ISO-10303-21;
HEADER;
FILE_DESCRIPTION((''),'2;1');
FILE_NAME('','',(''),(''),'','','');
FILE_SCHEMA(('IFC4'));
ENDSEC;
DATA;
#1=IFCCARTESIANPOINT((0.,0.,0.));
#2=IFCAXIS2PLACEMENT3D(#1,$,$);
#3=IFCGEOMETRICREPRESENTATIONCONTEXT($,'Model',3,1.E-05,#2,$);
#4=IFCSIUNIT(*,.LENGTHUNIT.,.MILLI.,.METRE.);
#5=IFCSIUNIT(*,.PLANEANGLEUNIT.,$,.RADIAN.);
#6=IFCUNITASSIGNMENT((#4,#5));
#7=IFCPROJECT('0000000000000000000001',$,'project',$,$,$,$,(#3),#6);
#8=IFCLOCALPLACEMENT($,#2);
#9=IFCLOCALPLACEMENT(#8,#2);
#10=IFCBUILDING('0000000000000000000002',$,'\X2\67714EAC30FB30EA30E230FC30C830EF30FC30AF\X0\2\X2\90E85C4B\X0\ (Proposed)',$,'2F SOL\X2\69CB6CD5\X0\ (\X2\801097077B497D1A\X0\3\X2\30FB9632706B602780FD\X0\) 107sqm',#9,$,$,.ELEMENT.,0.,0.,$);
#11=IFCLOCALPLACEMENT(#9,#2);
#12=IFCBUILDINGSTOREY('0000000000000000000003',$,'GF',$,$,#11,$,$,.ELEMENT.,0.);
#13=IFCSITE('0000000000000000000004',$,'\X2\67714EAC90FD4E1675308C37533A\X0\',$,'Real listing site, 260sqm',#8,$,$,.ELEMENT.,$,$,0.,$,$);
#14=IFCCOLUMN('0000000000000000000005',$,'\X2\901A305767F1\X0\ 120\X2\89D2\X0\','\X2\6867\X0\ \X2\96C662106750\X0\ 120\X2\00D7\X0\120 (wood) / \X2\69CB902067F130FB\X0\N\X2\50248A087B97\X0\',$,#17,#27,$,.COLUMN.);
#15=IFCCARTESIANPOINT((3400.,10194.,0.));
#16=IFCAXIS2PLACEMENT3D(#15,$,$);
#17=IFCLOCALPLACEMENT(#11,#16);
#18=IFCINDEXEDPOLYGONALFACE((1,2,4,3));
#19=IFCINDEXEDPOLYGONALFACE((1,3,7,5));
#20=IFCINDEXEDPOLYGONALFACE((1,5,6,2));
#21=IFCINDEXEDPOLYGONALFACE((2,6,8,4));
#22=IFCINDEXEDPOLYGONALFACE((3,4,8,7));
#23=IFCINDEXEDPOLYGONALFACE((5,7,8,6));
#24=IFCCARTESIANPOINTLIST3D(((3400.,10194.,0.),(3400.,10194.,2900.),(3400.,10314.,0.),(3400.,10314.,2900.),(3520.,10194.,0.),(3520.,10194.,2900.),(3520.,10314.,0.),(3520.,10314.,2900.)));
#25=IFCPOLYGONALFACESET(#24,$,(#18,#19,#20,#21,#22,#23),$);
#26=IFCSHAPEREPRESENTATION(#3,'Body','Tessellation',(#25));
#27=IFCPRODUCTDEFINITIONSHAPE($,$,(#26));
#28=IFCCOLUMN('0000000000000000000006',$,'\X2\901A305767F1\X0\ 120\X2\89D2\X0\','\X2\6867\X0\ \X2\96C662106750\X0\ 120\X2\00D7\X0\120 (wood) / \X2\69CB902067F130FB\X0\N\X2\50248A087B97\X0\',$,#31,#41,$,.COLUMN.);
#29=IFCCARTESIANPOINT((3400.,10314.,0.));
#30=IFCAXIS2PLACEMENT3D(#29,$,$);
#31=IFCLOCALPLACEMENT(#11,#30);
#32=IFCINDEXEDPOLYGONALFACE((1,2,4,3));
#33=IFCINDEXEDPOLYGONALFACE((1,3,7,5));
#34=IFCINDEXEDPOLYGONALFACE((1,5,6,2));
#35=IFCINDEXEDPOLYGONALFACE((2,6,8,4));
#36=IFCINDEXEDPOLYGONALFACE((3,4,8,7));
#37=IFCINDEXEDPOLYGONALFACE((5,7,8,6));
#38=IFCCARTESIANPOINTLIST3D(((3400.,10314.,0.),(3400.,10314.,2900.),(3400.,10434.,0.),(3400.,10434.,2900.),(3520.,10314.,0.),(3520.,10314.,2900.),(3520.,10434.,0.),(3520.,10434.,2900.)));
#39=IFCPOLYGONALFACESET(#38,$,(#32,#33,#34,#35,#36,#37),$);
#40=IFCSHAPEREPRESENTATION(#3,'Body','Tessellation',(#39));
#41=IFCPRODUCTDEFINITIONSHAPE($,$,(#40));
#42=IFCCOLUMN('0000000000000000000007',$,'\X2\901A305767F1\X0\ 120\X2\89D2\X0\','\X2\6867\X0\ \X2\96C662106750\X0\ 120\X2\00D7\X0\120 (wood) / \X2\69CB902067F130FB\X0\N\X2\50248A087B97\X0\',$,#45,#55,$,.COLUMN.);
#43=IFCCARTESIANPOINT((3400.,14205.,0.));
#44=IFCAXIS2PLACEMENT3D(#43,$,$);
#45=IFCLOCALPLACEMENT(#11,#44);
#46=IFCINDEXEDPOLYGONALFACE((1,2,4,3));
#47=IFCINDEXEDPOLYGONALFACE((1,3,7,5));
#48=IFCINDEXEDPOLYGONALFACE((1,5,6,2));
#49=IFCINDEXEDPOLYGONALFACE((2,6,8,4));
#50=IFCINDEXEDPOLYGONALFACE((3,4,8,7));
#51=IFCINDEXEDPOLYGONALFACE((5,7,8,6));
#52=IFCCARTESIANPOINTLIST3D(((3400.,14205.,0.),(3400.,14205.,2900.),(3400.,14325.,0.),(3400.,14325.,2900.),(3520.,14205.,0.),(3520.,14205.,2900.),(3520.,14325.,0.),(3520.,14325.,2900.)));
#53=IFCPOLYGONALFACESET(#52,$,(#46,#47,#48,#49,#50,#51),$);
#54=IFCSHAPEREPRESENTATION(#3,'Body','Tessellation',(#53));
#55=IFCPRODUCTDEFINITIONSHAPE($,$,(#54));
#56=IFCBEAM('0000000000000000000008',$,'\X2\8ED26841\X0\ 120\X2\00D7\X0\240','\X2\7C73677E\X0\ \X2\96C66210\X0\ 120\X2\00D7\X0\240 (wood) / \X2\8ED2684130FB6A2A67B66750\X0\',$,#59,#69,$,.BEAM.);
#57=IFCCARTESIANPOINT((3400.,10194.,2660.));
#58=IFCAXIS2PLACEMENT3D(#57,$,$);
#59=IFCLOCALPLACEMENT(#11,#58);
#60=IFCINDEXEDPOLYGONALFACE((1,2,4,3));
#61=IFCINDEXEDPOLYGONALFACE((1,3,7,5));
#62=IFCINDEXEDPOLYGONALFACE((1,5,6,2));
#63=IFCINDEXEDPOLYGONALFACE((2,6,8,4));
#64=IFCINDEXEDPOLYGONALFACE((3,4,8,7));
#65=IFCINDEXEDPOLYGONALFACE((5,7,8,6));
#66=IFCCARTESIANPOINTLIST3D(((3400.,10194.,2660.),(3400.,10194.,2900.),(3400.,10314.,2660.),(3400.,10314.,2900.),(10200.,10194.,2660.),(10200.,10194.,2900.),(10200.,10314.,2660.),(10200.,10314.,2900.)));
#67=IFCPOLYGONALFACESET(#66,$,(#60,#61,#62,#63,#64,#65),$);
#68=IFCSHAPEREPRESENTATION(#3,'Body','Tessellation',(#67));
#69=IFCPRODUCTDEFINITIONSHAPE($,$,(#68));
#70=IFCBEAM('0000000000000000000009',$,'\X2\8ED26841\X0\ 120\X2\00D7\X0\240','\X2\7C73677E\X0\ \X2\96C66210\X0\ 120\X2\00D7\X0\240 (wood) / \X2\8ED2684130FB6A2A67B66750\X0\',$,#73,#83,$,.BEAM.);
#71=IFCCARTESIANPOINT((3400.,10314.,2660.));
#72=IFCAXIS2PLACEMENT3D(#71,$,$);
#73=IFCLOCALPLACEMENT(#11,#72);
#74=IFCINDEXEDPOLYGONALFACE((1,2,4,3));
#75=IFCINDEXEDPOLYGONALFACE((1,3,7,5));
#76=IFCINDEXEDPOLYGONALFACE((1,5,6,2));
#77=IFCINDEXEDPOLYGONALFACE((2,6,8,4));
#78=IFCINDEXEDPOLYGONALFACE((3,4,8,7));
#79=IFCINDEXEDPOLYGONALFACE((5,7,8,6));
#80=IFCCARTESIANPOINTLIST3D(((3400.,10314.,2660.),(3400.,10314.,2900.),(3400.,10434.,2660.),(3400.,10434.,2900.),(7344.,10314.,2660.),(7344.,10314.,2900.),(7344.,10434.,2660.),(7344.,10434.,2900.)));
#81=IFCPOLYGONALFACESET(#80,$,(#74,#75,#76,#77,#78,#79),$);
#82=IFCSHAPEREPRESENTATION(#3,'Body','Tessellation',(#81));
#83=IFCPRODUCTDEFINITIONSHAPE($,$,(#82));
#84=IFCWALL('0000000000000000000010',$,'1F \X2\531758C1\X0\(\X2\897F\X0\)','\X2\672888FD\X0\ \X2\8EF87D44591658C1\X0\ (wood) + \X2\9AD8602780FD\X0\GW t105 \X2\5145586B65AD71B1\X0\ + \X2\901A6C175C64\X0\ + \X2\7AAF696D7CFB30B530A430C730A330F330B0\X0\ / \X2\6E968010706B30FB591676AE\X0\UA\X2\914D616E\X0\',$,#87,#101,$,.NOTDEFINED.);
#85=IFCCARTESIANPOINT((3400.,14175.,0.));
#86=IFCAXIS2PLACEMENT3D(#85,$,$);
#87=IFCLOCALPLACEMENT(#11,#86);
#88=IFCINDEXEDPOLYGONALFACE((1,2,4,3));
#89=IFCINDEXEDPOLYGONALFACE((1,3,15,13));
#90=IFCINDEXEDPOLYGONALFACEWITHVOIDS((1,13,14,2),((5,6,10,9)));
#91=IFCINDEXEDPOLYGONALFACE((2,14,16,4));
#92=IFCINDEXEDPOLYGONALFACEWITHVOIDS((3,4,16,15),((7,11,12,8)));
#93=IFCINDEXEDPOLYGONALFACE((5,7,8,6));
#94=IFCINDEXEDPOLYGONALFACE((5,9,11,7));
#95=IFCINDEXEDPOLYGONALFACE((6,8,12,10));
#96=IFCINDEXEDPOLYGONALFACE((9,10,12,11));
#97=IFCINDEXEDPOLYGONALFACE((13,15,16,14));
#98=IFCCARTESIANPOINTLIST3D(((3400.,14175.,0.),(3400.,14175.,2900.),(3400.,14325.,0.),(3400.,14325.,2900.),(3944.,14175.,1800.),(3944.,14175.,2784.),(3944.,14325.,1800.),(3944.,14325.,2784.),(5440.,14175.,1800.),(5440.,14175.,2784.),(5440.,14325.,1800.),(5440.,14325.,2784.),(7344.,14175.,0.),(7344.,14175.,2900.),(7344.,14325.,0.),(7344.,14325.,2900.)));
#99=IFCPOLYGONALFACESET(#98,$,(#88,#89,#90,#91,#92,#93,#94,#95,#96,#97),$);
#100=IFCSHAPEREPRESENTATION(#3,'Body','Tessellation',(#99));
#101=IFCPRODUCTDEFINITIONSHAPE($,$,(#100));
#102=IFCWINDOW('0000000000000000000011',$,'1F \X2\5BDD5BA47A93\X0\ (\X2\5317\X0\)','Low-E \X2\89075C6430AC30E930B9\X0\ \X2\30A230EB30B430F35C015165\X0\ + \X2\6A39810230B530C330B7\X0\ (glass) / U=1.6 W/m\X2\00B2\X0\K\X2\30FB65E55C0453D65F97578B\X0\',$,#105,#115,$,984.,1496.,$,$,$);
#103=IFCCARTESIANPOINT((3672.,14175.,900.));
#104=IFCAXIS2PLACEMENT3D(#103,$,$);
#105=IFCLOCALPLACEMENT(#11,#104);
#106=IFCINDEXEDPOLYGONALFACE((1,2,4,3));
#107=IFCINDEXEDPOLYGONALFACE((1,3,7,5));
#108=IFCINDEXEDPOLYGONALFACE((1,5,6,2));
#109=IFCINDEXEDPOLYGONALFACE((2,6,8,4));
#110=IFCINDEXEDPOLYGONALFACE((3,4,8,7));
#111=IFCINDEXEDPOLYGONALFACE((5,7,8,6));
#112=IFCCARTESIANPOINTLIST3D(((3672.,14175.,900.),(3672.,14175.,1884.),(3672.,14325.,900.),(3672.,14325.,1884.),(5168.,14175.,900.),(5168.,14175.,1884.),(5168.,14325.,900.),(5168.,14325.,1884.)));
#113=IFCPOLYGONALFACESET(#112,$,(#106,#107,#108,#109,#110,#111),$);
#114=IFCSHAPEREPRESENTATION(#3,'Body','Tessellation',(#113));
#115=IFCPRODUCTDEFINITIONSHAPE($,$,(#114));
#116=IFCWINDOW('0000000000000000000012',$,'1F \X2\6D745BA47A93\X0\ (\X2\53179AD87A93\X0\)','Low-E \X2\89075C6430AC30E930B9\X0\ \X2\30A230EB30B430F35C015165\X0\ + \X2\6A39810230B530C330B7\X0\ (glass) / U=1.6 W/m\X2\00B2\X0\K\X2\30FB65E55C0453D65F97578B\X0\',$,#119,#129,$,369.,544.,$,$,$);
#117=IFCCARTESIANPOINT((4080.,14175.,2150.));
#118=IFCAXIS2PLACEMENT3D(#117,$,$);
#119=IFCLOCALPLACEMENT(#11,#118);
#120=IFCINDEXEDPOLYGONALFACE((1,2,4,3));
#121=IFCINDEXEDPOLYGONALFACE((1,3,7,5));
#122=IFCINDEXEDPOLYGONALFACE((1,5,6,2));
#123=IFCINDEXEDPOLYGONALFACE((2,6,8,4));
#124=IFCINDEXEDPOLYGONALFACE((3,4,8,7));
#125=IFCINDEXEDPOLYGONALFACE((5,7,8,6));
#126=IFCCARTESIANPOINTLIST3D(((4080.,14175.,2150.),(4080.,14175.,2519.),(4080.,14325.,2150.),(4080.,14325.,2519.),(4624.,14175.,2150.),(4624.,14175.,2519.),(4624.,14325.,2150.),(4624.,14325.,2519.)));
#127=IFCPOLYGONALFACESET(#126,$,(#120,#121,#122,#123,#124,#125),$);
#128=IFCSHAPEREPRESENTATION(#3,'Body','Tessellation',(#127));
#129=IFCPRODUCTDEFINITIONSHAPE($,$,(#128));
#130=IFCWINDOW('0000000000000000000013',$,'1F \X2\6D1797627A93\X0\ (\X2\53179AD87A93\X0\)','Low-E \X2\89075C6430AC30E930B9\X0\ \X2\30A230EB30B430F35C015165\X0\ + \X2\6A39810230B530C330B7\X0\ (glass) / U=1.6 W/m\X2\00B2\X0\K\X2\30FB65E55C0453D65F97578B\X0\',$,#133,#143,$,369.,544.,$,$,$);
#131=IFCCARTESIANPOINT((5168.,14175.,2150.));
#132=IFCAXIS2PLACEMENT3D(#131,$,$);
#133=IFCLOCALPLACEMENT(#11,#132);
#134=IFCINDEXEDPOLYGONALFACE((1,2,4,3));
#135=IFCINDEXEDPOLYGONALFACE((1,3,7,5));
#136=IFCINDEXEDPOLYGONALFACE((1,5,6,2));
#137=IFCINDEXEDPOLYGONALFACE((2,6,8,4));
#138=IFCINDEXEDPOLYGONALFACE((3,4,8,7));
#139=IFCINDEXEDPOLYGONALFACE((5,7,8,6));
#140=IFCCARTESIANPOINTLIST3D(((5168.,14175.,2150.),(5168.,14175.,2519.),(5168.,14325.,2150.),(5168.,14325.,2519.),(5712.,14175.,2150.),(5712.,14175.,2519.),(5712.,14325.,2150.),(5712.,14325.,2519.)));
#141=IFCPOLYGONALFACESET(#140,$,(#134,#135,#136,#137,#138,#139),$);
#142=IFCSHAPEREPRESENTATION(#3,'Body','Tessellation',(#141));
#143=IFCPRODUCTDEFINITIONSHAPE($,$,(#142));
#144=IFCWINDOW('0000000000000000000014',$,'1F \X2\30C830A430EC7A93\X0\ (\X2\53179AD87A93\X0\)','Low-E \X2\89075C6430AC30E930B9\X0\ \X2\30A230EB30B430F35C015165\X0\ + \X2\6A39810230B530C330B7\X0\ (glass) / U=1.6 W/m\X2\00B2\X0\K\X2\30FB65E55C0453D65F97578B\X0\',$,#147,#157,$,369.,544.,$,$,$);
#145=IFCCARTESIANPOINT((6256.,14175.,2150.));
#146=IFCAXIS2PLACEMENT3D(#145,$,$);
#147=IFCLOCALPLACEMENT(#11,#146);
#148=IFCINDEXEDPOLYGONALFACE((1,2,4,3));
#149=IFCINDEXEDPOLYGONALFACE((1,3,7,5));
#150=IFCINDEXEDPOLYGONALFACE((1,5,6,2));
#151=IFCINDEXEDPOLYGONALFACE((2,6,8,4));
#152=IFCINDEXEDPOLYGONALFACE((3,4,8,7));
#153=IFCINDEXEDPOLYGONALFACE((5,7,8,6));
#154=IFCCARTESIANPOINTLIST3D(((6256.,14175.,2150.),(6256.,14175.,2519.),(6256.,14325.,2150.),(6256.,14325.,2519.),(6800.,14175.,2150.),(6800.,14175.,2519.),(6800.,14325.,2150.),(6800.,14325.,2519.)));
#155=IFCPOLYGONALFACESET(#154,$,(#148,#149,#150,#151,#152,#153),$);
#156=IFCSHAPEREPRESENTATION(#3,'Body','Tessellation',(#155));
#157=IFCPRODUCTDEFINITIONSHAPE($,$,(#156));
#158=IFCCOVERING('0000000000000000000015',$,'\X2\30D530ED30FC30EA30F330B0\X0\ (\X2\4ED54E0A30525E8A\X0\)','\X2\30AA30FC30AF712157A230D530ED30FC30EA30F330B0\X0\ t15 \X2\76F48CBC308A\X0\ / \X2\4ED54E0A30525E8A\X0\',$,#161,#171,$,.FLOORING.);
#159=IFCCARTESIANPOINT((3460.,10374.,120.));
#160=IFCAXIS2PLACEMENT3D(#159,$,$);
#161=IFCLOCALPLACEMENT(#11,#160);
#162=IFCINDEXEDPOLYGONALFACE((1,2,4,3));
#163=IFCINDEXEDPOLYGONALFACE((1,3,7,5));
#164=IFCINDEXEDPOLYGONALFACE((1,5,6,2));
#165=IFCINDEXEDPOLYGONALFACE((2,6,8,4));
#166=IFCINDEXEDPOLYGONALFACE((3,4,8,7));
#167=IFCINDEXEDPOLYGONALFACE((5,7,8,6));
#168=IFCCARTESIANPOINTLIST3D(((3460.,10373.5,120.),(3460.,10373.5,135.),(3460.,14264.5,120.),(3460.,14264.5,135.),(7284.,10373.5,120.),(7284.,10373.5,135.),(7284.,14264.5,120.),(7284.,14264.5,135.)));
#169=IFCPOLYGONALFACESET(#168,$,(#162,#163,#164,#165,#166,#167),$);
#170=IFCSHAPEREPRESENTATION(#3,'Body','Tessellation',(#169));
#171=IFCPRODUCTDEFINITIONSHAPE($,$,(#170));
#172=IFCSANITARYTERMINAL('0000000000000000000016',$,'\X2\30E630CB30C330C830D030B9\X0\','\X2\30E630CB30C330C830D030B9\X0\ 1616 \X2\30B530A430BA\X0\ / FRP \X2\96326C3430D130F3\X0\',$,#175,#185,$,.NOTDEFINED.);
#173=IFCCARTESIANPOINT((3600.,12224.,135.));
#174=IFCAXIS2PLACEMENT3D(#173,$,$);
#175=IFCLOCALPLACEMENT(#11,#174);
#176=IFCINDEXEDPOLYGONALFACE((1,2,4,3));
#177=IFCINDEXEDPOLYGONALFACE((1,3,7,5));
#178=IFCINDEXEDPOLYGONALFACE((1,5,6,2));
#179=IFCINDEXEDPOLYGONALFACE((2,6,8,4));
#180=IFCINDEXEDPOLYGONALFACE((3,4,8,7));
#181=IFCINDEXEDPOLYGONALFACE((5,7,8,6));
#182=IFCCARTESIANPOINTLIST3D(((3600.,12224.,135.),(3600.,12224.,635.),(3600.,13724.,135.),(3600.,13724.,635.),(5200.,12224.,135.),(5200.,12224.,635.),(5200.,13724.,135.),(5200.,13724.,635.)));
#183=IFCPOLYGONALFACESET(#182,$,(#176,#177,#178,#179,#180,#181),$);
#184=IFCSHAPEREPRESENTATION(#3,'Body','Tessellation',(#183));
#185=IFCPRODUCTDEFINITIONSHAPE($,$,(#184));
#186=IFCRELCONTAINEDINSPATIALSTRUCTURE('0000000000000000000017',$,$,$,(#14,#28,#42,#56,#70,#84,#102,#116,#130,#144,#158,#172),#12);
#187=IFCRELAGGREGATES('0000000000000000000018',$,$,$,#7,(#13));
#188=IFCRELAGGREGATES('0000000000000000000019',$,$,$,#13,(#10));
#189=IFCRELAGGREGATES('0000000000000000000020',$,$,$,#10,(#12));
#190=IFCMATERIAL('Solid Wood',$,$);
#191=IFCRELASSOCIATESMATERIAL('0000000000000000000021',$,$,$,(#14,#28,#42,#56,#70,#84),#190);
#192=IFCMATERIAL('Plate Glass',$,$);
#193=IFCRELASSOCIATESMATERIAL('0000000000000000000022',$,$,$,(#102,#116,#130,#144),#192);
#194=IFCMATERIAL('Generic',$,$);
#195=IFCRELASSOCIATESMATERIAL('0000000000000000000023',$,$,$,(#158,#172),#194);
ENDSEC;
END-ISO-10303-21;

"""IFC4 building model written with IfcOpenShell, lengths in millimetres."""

from ifc_helpers import new_model, si_unit, frame, frame_2d, origin, place, context, project, spatial, rectangle, extrude, material, element, fill, save


model = new_model("IFC4")

# Units and contexts
model_context = context("Model", 3, precision=1e-05, world=origin())
ifc_project = project(units=[si_unit("LENGTHUNIT", "METRE", prefix="MILLI"), si_unit("PLANEANGLEUNIT", "RADIAN")], contexts=[model_context])

# Site, building, storey
site_placement = place(None, origin())
site = spatial("IfcSite", under=ifc_project, at=site_placement, Name="東京都世田谷区", ObjectType="Real listing site, 260sqm", CompositionType="ELEMENT", RefElevation=0.0)
building_placement = place(site_placement, origin())
building = spatial("IfcBuilding", under=site, at=building_placement, Name="東京・リモートワーク2部屋 (Proposed)", ObjectType="2F SOL構法 (耐震等級3・防火性能) 107sqm", CompositionType="ELEMENT", ElevationOfRefHeight=0.0, ElevationOfTerrain=0.0)
storey_placement = place(building_placement, origin())
storey = spatial("IfcBuildingStorey", under=building, at=storey_placement, Name="GF", CompositionType="ELEMENT", Elevation=0.0)

# Columns
ifc_material_1 = material(Name="Solid Wood")
column_1_placement = place(storey_placement, frame((3400.0, 10194.0, 0.0)))
element("IfcColumn", 1, at=column_1_placement, inside=storey, material=ifc_material_1, Name="通し柱 120角", Description="桧 集成材 120×120 (wood) / 構造柱・N値計算", PredefinedType="COLUMN", context=model_context, shape_type="SweptSolid", body=[
    extrude(rectangle(XDim=120.0, YDim=120.0, at=frame_2d((60.0, 60.0))), frame((3400.0, 10194.0, 0.0)), (0.0, 0.0, 1.0), 2900.0),
])
column_2_placement = place(storey_placement, frame((3400.0, 10314.0, 0.0)))
element("IfcColumn", 2, at=column_2_placement, inside=storey, material=ifc_material_1, Name="通し柱 120角", Description="桧 集成材 120×120 (wood) / 構造柱・N値計算", PredefinedType="COLUMN", context=model_context, shape_type="SweptSolid", body=[
    extrude(rectangle(XDim=120.0, YDim=120.0, at=frame_2d((60.0, 60.0))), frame((3400.0, 10314.0, 0.0)), (0.0, 0.0, 1.0), 2900.0),
])
column_3_placement = place(storey_placement, frame((3400.0, 14205.0, 0.0)))
element("IfcColumn", 3, at=column_3_placement, inside=storey, material=ifc_material_1, Name="通し柱 120角", Description="桧 集成材 120×120 (wood) / 構造柱・N値計算", PredefinedType="COLUMN", context=model_context, shape_type="SweptSolid", body=[
    extrude(rectangle(XDim=120.0, YDim=120.0, at=frame_2d((60.0, 60.0))), frame((3400.0, 14205.0, 0.0)), (0.0, 0.0, 1.0), 2900.0),
])

# Beams
beam_1_placement = place(storey_placement, frame((3400.0, 10194.0, 2660.0)))
element("IfcBeam", 4, at=beam_1_placement, inside=storey, material=ifc_material_1, Name="軒桁 120×240", Description="米松 集成 120×240 (wood) / 軒桁・横架材", PredefinedType="BEAM", context=model_context, shape_type="SweptSolid", body=[
    extrude(rectangle(XDim=6800.0, YDim=120.0, at=frame_2d((3400.0, 60.0))), frame((3400.0, 10194.0, 2660.0)), (0.0, 0.0, 1.0), 240.0),
])
beam_2_placement = place(storey_placement, frame((3400.0, 10314.0, 2660.0)))
element("IfcBeam", 5, at=beam_2_placement, inside=storey, material=ifc_material_1, Name="軒桁 120×240", Description="米松 集成 120×240 (wood) / 軒桁・横架材", PredefinedType="BEAM", context=model_context, shape_type="SweptSolid", body=[
    extrude(rectangle(XDim=3944.0, YDim=120.0, at=frame_2d((1972.0, 60.0))), frame((3400.0, 10314.0, 2660.0)), (0.0, 0.0, 1.0), 240.0),
])

# Wall, openings, windows
wall_1_placement = place(storey_placement, frame((3400.0, 14175.0, 0.0)))
wall_1 = element("IfcWall", 6, at=wall_1_placement, inside=storey, material=ifc_material_1, Name="1F 北壁(西)", Description="木製 軸組外壁 (wood) + 高性能GW t105 充填断熱 + 通気層 + 窯業系サイディング / 準耐火・外皮UA配慮", PredefinedType="NOTDEFINED", context=model_context, shape_type="SweptSolid", body=[
    extrude(rectangle(XDim=3944.0, YDim=150.0, at=frame_2d((1972.0, 75.0))), frame((3400.0, 14175.0, 0.0)), (0.0, 0.0, 1.0), 2900.0),
])
opening_1_placement = place(storey_placement, frame((3672.0, 14175.0, 900.0)))
opening_1 = element("IfcOpeningElement", 7, at=opening_1_placement, cuts=wall_1, PredefinedType="NOTDEFINED", context=model_context, shape_type="SweptSolid", body=[
    extrude(rectangle(XDim=1496.0, YDim=150.0, at=frame_2d((748.0, 75.0))), frame((3672.0, 14175.0, 900.0)), (0.0, 0.0, 1.0), 984.0),
])
opening_2_placement = place(storey_placement, frame((4080.0, 14175.0, 2150.0)))
opening_2 = element("IfcOpeningElement", 8, at=opening_2_placement, cuts=wall_1, PredefinedType="NOTDEFINED", context=model_context, shape_type="SweptSolid", body=[
    extrude(rectangle(XDim=544.0, YDim=150.0, at=frame_2d((272.0, 75.0))), frame((4080.0, 14175.0, 2150.0)), (0.0, 0.0, 1.0), 369.0),
])
opening_3_placement = place(storey_placement, frame((5168.0, 14175.0, 2150.0)))
opening_3 = element("IfcOpeningElement", 9, at=opening_3_placement, cuts=wall_1, PredefinedType="NOTDEFINED", context=model_context, shape_type="SweptSolid", body=[
    extrude(rectangle(XDim=544.0, YDim=150.0, at=frame_2d((272.0, 75.0))), frame((5168.0, 14175.0, 2150.0)), (0.0, 0.0, 1.0), 369.0),
])
opening_4_placement = place(storey_placement, frame((6256.0, 14175.0, 2150.0)))
opening_4 = element("IfcOpeningElement", 10, at=opening_4_placement, cuts=wall_1, PredefinedType="NOTDEFINED", context=model_context, shape_type="SweptSolid", body=[
    extrude(rectangle(XDim=544.0, YDim=150.0, at=frame_2d((272.0, 75.0))), frame((6256.0, 14175.0, 2150.0)), (0.0, 0.0, 1.0), 369.0),
])
ifc_material_2 = material(Name="Plate Glass")
window_1_placement = place(storey_placement, frame((3672.0, 14175.0, 900.0)))
window_1 = element("IfcWindow", 11, at=window_1_placement, inside=storey, material=ifc_material_2, Name="1F 寝室窓 (北)", Description="Low-E 複層ガラス アルゴン封入 + 樹脂サッシ (glass) / U=1.6 W/m²K・日射取得型", OverallHeight=984.0, OverallWidth=1496.0, context=model_context, shape_type="SweptSolid", body=[
    extrude(rectangle(XDim=1496.0, YDim=150.0, at=frame_2d((748.0, 75.0))), frame((3672.0, 14175.0, 900.0)), (0.0, 0.0, 1.0), 984.0),
])
fill(opening_1, window_1)
window_2_placement = place(storey_placement, frame((4080.0, 14175.0, 2150.0)))
window_2 = element("IfcWindow", 12, at=window_2_placement, inside=storey, material=ifc_material_2, Name="1F 浴室窓 (北高窓)", Description="Low-E 複層ガラス アルゴン封入 + 樹脂サッシ (glass) / U=1.6 W/m²K・日射取得型", OverallHeight=369.0, OverallWidth=544.0, context=model_context, shape_type="SweptSolid", body=[
    extrude(rectangle(XDim=544.0, YDim=150.0, at=frame_2d((272.0, 75.0))), frame((4080.0, 14175.0, 2150.0)), (0.0, 0.0, 1.0), 369.0),
])
fill(opening_2, window_2)
window_3_placement = place(storey_placement, frame((5168.0, 14175.0, 2150.0)))
window_3 = element("IfcWindow", 13, at=window_3_placement, inside=storey, material=ifc_material_2, Name="1F 洗面窓 (北高窓)", Description="Low-E 複層ガラス アルゴン封入 + 樹脂サッシ (glass) / U=1.6 W/m²K・日射取得型", OverallHeight=369.0, OverallWidth=544.0, context=model_context, shape_type="SweptSolid", body=[
    extrude(rectangle(XDim=544.0, YDim=150.0, at=frame_2d((272.0, 75.0))), frame((5168.0, 14175.0, 2150.0)), (0.0, 0.0, 1.0), 369.0),
])
fill(opening_3, window_3)
window_4_placement = place(storey_placement, frame((6256.0, 14175.0, 2150.0)))
window_4 = element("IfcWindow", 14, at=window_4_placement, inside=storey, material=ifc_material_2, Name="1F トイレ窓 (北高窓)", Description="Low-E 複層ガラス アルゴン封入 + 樹脂サッシ (glass) / U=1.6 W/m²K・日射取得型", OverallHeight=369.0, OverallWidth=544.0, context=model_context, shape_type="SweptSolid", body=[
    extrude(rectangle(XDim=544.0, YDim=150.0, at=frame_2d((272.0, 75.0))), frame((6256.0, 14175.0, 2150.0)), (0.0, 0.0, 1.0), 369.0),
])
fill(opening_4, window_4)

# Covering
ifc_material_3 = material(Name="Generic")
covering_placement = place(storey_placement, frame((3460.0, 10374.0, 120.0)))
element("IfcCovering", 15, at=covering_placement, inside=storey, material=ifc_material_3, Name="フローリング (仕上げ床)", Description="オーク無垢フローリング t15 直貼り / 仕上げ床", PredefinedType="FLOORING", context=model_context, shape_type="SweptSolid", body=[
    extrude(rectangle(XDim=3824.0, YDim=3891.0, at=frame_2d((1912.0, 1945.0))), frame((3460.0, 10374.0, 120.0)), (0.0, 0.0, 1.0), 15.0),
])

# Sanitary terminal
sanitary_terminal_placement = place(storey_placement, frame((3600.0, 12224.0, 135.0)))
element("IfcSanitaryTerminal", 16, at=sanitary_terminal_placement, inside=storey, material=ifc_material_3, Name="ユニットバス", Description="ユニットバス 1616 サイズ / FRP 防水パン", PredefinedType="NOTDEFINED", context=model_context, shape_type="SweptSolid", body=[
    extrude(rectangle(XDim=1600.0, YDim=1500.0, at=frame_2d((800.0, 750.0))), frame((3600.0, 12224.0, 135.0)), (0.0, 0.0, 1.0), 500.0),
])

save(model, "model.ifc")
